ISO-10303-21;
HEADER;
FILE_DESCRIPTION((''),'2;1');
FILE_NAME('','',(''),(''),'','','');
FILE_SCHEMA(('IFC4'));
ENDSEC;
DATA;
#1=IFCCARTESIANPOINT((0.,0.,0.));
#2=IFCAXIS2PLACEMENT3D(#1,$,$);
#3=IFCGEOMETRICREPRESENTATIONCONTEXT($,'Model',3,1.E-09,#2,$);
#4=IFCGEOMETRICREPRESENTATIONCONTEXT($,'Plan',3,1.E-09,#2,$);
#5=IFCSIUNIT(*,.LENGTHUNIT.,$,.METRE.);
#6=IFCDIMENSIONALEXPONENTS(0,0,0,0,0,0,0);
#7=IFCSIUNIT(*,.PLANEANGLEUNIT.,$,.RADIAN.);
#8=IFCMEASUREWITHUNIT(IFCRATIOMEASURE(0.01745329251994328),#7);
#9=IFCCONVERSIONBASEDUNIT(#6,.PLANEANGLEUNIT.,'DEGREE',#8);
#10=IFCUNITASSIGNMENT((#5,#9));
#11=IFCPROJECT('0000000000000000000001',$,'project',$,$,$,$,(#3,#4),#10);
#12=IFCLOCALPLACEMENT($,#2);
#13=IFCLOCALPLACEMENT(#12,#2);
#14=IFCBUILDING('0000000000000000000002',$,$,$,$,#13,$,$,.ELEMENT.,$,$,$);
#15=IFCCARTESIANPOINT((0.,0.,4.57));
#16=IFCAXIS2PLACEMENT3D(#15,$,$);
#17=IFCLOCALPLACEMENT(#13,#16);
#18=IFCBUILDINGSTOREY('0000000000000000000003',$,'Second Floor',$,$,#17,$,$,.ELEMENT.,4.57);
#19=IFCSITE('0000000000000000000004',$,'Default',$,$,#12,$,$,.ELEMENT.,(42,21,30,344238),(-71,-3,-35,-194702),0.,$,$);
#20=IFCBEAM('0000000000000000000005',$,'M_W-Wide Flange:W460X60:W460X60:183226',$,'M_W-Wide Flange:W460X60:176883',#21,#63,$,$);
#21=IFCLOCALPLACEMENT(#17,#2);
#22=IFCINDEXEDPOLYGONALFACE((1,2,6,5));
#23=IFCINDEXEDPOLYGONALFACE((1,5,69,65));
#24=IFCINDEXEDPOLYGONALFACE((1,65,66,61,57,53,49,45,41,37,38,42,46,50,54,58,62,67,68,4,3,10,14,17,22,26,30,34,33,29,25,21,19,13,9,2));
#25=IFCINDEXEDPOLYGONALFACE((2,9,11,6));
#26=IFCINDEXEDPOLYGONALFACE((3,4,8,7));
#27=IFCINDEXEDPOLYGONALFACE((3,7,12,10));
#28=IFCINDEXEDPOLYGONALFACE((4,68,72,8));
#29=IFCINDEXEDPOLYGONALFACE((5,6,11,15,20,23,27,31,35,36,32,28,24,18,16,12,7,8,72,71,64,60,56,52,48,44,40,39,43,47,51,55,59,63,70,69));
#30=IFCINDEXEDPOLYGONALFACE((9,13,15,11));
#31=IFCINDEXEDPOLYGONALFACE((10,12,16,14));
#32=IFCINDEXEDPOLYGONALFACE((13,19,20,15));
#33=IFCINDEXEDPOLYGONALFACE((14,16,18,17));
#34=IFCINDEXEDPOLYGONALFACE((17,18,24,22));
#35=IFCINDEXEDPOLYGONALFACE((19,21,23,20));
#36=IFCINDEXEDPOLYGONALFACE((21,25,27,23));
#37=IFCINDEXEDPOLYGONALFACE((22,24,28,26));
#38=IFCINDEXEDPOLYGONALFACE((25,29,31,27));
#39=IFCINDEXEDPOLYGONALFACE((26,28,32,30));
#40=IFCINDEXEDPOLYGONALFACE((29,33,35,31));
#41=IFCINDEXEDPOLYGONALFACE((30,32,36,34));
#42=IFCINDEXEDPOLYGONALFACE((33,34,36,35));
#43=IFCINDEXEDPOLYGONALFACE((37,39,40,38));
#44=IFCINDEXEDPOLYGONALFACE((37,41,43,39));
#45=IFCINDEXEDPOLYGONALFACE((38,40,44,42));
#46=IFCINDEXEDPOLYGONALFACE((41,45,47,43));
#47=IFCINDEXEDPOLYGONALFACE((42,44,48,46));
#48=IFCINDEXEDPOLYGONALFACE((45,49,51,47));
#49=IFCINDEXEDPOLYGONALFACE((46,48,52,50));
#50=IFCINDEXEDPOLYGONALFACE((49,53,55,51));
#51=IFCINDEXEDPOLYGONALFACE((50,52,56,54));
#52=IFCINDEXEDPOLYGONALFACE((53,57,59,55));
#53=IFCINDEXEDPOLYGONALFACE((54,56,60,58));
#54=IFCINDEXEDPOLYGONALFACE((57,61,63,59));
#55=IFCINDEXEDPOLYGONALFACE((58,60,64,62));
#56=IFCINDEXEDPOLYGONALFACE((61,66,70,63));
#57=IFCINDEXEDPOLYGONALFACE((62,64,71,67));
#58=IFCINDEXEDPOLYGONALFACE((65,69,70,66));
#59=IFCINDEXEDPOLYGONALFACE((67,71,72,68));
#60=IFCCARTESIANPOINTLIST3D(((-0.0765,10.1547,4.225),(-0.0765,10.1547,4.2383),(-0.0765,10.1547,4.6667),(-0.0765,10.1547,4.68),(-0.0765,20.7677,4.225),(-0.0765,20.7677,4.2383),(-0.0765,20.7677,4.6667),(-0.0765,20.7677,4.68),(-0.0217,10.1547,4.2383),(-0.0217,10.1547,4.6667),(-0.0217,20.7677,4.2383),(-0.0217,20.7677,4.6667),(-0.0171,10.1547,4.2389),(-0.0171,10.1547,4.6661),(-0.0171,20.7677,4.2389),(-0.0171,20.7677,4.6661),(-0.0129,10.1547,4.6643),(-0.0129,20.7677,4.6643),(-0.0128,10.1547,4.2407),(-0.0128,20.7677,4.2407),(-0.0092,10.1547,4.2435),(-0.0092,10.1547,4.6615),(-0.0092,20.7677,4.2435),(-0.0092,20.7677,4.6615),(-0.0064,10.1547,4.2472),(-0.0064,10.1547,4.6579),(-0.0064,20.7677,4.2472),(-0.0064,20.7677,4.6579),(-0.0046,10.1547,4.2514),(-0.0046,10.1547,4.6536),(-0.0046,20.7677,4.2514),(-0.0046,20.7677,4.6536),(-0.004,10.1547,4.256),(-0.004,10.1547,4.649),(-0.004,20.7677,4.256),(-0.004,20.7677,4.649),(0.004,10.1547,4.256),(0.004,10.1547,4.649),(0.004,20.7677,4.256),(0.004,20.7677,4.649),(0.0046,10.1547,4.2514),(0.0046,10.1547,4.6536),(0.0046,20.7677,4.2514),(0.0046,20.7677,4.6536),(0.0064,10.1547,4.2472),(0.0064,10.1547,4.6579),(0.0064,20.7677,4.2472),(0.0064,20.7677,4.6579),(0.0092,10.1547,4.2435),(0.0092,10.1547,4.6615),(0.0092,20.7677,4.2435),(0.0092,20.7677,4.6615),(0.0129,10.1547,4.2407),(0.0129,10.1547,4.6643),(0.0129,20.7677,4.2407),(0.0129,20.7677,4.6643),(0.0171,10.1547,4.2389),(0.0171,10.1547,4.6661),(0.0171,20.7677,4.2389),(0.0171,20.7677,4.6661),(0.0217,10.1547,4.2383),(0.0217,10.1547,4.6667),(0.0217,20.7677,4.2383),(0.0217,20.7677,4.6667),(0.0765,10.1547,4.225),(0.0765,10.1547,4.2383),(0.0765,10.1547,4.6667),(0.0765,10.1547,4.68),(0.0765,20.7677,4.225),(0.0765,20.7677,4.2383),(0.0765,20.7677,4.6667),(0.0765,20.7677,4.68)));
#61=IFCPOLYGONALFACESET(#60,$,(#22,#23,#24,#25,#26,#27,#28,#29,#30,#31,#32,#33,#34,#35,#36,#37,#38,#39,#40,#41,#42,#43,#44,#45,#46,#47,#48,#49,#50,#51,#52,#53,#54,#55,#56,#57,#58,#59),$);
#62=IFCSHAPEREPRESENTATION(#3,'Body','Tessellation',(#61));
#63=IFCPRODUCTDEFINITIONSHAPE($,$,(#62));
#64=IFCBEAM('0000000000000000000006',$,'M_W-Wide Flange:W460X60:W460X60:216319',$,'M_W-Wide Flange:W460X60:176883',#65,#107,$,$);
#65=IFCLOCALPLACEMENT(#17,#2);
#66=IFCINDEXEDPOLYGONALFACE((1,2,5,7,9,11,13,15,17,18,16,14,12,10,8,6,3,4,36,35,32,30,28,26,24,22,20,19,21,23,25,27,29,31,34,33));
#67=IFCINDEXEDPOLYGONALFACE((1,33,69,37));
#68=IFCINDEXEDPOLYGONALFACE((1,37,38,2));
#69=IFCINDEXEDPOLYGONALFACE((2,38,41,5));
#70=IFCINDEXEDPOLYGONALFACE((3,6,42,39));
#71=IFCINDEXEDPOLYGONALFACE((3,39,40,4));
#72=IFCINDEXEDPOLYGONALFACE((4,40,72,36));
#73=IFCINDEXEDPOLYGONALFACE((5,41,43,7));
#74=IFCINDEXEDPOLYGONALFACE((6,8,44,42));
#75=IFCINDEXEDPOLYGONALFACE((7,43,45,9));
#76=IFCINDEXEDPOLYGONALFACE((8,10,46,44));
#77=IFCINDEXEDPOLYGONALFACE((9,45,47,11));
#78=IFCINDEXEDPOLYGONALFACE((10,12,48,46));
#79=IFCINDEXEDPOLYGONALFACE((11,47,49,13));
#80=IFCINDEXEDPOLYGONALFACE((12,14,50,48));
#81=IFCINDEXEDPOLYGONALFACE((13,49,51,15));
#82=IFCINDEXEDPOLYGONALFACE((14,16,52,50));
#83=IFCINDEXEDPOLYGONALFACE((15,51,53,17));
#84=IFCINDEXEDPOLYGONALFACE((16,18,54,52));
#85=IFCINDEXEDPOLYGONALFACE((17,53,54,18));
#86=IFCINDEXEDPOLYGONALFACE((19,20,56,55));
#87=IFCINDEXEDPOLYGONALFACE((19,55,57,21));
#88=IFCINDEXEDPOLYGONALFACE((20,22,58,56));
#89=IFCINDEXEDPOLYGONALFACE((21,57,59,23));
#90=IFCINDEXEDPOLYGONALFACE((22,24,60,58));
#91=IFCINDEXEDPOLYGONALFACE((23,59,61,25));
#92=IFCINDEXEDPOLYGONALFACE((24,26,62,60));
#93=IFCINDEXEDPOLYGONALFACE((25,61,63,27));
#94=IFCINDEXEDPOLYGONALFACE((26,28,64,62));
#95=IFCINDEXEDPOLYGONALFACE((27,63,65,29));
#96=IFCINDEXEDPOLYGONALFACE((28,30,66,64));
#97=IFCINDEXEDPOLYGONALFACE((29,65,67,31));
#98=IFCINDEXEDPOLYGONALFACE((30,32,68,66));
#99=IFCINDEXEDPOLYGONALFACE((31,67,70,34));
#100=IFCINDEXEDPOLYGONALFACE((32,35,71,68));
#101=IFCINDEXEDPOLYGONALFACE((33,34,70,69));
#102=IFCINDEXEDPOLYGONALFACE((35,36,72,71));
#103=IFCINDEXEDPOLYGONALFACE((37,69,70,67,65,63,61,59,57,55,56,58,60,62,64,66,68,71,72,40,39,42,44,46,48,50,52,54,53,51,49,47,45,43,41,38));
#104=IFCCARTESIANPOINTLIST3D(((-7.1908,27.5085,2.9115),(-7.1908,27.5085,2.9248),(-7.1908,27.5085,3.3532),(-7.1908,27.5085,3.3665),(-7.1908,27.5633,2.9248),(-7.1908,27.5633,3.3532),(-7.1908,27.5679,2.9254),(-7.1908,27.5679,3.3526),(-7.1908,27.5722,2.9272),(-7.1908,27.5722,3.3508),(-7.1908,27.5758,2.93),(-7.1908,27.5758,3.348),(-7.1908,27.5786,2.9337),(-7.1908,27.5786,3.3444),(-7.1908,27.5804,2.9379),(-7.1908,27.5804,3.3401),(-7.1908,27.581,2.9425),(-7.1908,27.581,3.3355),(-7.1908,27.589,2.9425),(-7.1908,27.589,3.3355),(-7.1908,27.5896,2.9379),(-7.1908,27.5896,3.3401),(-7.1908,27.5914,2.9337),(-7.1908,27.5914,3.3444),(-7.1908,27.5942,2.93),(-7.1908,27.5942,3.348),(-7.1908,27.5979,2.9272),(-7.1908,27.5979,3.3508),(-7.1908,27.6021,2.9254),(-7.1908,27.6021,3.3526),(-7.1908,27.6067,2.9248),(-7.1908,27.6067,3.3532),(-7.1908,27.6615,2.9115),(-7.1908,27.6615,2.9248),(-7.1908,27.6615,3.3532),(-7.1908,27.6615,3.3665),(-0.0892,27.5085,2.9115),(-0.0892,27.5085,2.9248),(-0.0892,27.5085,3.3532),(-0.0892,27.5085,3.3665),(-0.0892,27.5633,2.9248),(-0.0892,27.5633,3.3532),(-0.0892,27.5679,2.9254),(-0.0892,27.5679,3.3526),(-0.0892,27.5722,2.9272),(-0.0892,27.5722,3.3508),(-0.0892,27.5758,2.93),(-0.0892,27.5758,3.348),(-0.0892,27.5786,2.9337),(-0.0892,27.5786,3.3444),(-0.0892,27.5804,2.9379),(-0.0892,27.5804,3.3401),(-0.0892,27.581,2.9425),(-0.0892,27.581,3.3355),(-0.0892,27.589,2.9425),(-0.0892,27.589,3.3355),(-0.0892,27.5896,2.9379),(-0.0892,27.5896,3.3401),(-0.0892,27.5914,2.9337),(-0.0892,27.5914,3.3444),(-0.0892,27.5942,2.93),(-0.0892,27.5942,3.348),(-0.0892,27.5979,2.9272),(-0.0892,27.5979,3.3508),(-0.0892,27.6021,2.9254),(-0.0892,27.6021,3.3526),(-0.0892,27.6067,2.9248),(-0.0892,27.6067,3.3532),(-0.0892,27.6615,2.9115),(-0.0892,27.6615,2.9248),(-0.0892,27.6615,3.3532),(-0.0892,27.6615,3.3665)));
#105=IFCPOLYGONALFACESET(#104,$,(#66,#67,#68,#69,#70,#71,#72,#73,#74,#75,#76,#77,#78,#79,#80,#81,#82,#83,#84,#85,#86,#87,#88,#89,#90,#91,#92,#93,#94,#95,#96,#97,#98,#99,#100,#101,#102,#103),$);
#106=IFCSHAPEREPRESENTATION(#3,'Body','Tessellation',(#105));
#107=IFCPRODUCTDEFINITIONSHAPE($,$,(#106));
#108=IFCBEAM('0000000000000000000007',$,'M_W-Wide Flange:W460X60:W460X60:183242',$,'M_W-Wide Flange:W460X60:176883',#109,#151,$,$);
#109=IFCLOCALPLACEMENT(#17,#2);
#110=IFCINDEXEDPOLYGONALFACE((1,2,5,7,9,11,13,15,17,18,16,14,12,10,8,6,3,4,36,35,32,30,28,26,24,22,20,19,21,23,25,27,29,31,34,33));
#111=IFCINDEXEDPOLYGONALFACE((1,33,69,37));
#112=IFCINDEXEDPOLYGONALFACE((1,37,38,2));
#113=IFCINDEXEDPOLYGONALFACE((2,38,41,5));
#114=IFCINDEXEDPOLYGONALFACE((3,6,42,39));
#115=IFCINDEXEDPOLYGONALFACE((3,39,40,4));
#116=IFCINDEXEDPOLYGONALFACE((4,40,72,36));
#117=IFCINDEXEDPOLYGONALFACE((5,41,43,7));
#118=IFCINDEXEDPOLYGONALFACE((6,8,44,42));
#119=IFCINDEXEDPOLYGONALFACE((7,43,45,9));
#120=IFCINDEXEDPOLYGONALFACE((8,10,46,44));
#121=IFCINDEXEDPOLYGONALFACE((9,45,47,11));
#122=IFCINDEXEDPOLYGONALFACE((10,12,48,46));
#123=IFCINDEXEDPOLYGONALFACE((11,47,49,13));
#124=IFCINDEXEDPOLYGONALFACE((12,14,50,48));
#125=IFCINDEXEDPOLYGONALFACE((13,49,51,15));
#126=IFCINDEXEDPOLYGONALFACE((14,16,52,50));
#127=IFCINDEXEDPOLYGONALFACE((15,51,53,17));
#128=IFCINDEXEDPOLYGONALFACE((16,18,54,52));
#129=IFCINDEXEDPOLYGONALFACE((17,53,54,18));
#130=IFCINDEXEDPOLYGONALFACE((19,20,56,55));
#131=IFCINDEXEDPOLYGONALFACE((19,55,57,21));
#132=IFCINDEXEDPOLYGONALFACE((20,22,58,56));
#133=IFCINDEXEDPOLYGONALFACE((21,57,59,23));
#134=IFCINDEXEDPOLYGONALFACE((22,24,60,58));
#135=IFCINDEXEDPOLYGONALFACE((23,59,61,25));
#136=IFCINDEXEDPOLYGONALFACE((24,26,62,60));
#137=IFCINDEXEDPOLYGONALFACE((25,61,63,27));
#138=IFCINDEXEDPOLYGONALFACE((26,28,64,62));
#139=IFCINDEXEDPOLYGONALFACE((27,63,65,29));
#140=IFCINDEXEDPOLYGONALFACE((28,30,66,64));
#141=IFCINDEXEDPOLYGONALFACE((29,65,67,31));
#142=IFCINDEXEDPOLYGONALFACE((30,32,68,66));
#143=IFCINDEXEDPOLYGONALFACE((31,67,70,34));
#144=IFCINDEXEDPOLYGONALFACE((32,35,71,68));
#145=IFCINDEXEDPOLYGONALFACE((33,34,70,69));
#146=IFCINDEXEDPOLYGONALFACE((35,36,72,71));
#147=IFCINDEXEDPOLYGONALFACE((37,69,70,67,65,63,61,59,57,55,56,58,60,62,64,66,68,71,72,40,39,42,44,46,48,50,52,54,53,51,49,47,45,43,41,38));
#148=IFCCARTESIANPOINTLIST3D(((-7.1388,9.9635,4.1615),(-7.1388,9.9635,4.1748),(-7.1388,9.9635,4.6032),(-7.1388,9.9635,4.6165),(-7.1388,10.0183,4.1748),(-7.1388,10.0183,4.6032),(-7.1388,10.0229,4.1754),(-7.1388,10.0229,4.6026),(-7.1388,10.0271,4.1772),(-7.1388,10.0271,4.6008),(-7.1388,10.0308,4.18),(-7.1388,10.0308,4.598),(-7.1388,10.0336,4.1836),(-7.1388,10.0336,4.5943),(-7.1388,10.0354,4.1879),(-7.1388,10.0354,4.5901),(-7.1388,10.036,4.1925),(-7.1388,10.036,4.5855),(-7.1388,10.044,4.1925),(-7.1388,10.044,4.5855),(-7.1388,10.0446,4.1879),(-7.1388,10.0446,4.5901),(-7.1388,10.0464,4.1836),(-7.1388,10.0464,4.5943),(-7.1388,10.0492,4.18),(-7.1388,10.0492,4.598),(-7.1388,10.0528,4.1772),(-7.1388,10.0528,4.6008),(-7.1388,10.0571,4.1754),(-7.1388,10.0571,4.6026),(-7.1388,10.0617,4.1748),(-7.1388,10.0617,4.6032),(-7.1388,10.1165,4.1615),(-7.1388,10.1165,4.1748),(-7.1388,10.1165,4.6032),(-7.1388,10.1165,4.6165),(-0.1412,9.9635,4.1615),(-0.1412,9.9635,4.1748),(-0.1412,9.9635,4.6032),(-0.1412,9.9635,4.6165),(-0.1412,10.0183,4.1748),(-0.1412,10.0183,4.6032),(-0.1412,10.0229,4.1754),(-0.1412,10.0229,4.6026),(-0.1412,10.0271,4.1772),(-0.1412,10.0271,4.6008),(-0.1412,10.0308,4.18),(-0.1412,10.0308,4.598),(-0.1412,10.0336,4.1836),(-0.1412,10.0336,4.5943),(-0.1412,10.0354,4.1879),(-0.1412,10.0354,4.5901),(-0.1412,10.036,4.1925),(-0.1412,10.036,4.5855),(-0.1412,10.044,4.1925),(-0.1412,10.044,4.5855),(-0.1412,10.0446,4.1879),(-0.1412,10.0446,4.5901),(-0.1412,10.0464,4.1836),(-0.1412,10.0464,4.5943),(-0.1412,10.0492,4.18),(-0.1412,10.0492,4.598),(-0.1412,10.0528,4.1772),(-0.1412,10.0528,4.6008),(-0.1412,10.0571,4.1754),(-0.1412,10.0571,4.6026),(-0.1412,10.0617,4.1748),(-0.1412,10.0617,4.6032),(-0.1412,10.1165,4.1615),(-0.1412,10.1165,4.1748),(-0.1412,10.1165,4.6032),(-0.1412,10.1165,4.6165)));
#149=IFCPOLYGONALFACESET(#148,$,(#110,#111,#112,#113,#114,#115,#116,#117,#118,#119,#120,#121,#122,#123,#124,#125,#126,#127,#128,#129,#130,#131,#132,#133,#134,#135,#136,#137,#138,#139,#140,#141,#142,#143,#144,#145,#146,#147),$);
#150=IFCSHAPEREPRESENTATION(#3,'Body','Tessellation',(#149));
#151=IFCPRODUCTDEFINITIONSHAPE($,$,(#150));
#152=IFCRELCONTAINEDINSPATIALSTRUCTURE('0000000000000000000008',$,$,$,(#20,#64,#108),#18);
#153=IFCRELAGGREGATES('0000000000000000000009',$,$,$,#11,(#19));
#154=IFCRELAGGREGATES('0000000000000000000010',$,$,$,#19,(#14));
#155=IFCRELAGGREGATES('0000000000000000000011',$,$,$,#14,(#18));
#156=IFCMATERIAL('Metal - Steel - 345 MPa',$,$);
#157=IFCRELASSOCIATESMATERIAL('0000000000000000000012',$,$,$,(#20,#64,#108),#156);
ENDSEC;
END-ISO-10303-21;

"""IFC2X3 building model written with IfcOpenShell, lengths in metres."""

from ifc_helpers import new_model, entity, si_unit, converted_unit, frame, frame_2d, origin, place, context, project, spatial, polyline, circle_curve, parameter, trimmed, segment, composite_curve, outline, extrude, material, element, save


model = new_model("IFC2X3")

# Units and contexts
model_context = context("Model", 3, precision=1e-09, world=origin())
plan_context = context("Plan", 3, precision=1e-09, world=origin())
ifc_project = project(units=[si_unit("LENGTHUNIT", "METRE"), converted_unit("PLANEANGLEUNIT", "DEGREE", entity("IfcRatioMeasure", 0.01745329251994328), si_unit("PLANEANGLEUNIT", "RADIAN"), dimensions=[0, 0, 0, 0, 0, 0, 0])], contexts=[model_context, plan_context])

# Site, building, storey
site_placement = place(None, origin())
site = spatial("IfcSite", under=ifc_project, at=site_placement, Name="Default", CompositionType="ELEMENT", RefLatitude=(42, 21, 30, 344238), RefLongitude=(-71, -3, -35, -194702), RefElevation=0.0)
building_placement = place(site_placement, origin())
building = spatial("IfcBuilding", under=site, at=building_placement, CompositionType="ELEMENT")
storey_placement = place(building_placement, frame((0.0, 0.0, 4.57)))
storey = spatial("IfcBuildingStorey", under=building, at=storey_placement, Name="Second Floor", CompositionType="ELEMENT", Elevation=4.57)

# Shared definitions
ifc_material = material(Name="Metal - Steel - 345 MPa")

# Beams
beam_1_placement = place(storey_placement, frame((0.0, 20.9072, 4.68), z_axis=(0.0, 0.0, 1.0), x_axis=(-1.0, 0.0, 0.0)))
element("IfcBeam", 1, at=beam_1_placement, inside=storey, material=ifc_material, Name="M_W-Wide Flange:W460X60:W460X60:183226", ObjectType="M_W-Wide Flange:W460X60:176883", context=model_context, shape_type="SweptSolid", body=[
    extrude(outline(composite_curve([segment(polyline([(0.2142, -0.0765), (0.2275, -0.0765)]), True, "CONTINUOUS"), segment(polyline([(0.2275, -0.0765), (0.2275, 0.0765)]), True, "CONTINUOUS"), segment(polyline([(0.2275, 0.0765), (0.2142, 0.0765)]), True, "CONTINUOUS"), segment(polyline([(0.2142, 0.0765), (0.2142, 0.0217)]), True, "CONTINUOUS"), segment(trimmed(circle_curve(frame_2d((0.1965, 0.0217), x_axis=(1.0, 0.0)), 0.0177), [parameter(270.0)], [parameter(360.0)], True, "PARAMETER"), False, "CONTINUOUS"), segment(polyline([(0.1965, 0.004), (-0.1965, 0.004)]), True, "CONTINUOUS"), segment(trimmed(circle_curve(frame_2d((-0.1965, 0.0217), x_axis=(0.0, -1.0)), 0.0177), [parameter(270.0)], [parameter(360.0)], True, "PARAMETER"), False, "CONTINUOUS"), segment(polyline([(-0.2142, 0.0217), (-0.2142, 0.0765)]), True, "CONTINUOUS"), segment(polyline([(-0.2142, 0.0765), (-0.2275, 0.0765)]), True, "CONTINUOUS"), segment(polyline([(-0.2275, 0.0765), (-0.2275, -0.0765)]), True, "CONTINUOUS"), segment(polyline([(-0.2275, -0.0765), (-0.2142, -0.0765)]), True, "CONTINUOUS"), segment(polyline([(-0.2142, -0.0765), (-0.2142, -0.0217)]), True, "CONTINUOUS"), segment(trimmed(circle_curve(frame_2d((-0.1965, -0.0217), x_axis=(-1.0, 0.0)), 0.0177), [parameter(270.0)], [parameter(360.0)], True, "PARAMETER"), False, "CONTINUOUS"), segment(polyline([(-0.1965, -0.004), (0.1965, -0.004)]), True, "CONTINUOUS"), segment(trimmed(circle_curve(frame_2d((0.1965, -0.0217), x_axis=(0.0, 1.0)), 0.0177), [parameter(270.0)], [parameter(0.0)], True, "PARAMETER"), False, "CONTINUOUS"), segment(polyline([(0.2142, -0.0217), (0.2142, -0.0765)]), True, "CONTINUOUS")], self_intersect=False)), frame((0.0, 10.7525, -0.2275), z_axis=(0.0, -1.0, 0.0), x_axis=(0.0, 0.0, -1.0)), (0.0, 0.0, 1.0), 10.613),
])
beam_2_placement = place(storey_placement, frame((-7.2774, 27.585, 3.3665), z_axis=(0.0, 0.0, 1.0), x_axis=(0.0, -1.0, 0.0)))
element("IfcBeam", 2, at=beam_2_placement, inside=storey, material=ifc_material, Name="M_W-Wide Flange:W460X60:W460X60:216319", ObjectType="M_W-Wide Flange:W460X60:176883", context=model_context, shape_type="SweptSolid", body=[
    extrude(outline(composite_curve([segment(polyline([(0.2142, -0.0765), (0.2275, -0.0765)]), True, "CONTINUOUS"), segment(polyline([(0.2275, -0.0765), (0.2275, 0.0765)]), True, "CONTINUOUS"), segment(polyline([(0.2275, 0.0765), (0.2142, 0.0765)]), True, "CONTINUOUS"), segment(polyline([(0.2142, 0.0765), (0.2142, 0.0217)]), True, "CONTINUOUS"), segment(trimmed(circle_curve(frame_2d((0.1965, 0.0217), x_axis=(0.0, 1.0)), 0.0177), [parameter(180.0)], [parameter(270.0)], True, "PARAMETER"), False, "CONTINUOUS"), segment(polyline([(0.1965, 0.004), (-0.1965, 0.004)]), True, "CONTINUOUS"), segment(trimmed(circle_curve(frame_2d((-0.1965, 0.0217), x_axis=(0.0, 1.0)), 0.0177), [parameter(90.0)], [parameter(180.0)], True, "PARAMETER"), False, "CONTINUOUS"), segment(polyline([(-0.2142, 0.0217), (-0.2142, 0.0765)]), True, "CONTINUOUS"), segment(polyline([(-0.2142, 0.0765), (-0.2275, 0.0765)]), True, "CONTINUOUS"), segment(polyline([(-0.2275, 0.0765), (-0.2275, -0.0765)]), True, "CONTINUOUS"), segment(polyline([(-0.2275, -0.0765), (-0.2142, -0.0765)]), True, "CONTINUOUS"), segment(polyline([(-0.2142, -0.0765), (-0.2142, -0.0217)]), True, "CONTINUOUS"), segment(trimmed(circle_curve(frame_2d((-0.1965, -0.0217), x_axis=(0.0, 1.0)), 0.0177), [parameter(360.0)], [parameter(90.0)], True, "PARAMETER"), False, "CONTINUOUS"), segment(polyline([(-0.1965, -0.004), (0.1965, -0.004)]), True, "CONTINUOUS"), segment(trimmed(circle_curve(frame_2d((0.1965, -0.0217), x_axis=(0.0, 1.0)), 0.0177), [parameter(270.0)], [parameter(0.0)], True, "PARAMETER"), False, "CONTINUOUS"), segment(polyline([(0.2142, -0.0217), (0.2142, -0.0765)]), True, "CONTINUOUS")], self_intersect=False)), frame((0.0, 0.0866, -0.2275), z_axis=(0.0, 1.0, 0.0), x_axis=(0.0, 0.0, -1.0)), (0.0, 0.0, 1.0), 7.1016),
])
beam_3_placement = place(storey_placement, frame((-0.0026, 10.04, 4.6165), z_axis=(0.0, 0.0, 1.0), x_axis=(0.0, 1.0, 0.0)))
element("IfcBeam", 3, at=beam_3_placement, inside=storey, material=ifc_material, Name="M_W-Wide Flange:W460X60:W460X60:183242", ObjectType="M_W-Wide Flange:W460X60:176883", context=model_context, shape_type="SweptSolid", body=[
    extrude(outline(composite_curve([segment(polyline([(0.2142, -0.0765), (0.2275, -0.0765)]), True, "CONTINUOUS"), segment(polyline([(0.2275, -0.0765), (0.2275, 0.0765)]), True, "CONTINUOUS"), segment(polyline([(0.2275, 0.0765), (0.2142, 0.0765)]), True, "CONTINUOUS"), segment(polyline([(0.2142, 0.0765), (0.2142, 0.0217)]), True, "CONTINUOUS"), segment(trimmed(circle_curve(frame_2d((0.1965, 0.0217), x_axis=(1.0, 0.0)), 0.0177), [parameter(270.0)], [parameter(360.0)], True, "PARAMETER"), False, "CONTINUOUS"), segment(polyline([(0.1965, 0.004), (-0.1965, 0.004)]), True, "CONTINUOUS"), segment(trimmed(circle_curve(frame_2d((-0.1965, 0.0217), x_axis=(0.0, -1.0)), 0.0177), [parameter(270.0)], [parameter(360.0)], True, "PARAMETER"), False, "CONTINUOUS"), segment(polyline([(-0.2142, 0.0217), (-0.2142, 0.0765)]), True, "CONTINUOUS"), segment(polyline([(-0.2142, 0.0765), (-0.2275, 0.0765)]), True, "CONTINUOUS"), segment(polyline([(-0.2275, 0.0765), (-0.2275, -0.0765)]), True, "CONTINUOUS"), segment(polyline([(-0.2275, -0.0765), (-0.2142, -0.0765)]), True, "CONTINUOUS"), segment(polyline([(-0.2142, -0.0765), (-0.2142, -0.0217)]), True, "CONTINUOUS"), segment(trimmed(circle_curve(frame_2d((-0.1965, -0.0217), x_axis=(-1.0, 0.0)), 0.0177), [parameter(270.0)], [parameter(360.0)], True, "PARAMETER"), False, "CONTINUOUS"), segment(polyline([(-0.1965, -0.004), (0.1965, -0.004)]), True, "CONTINUOUS"), segment(trimmed(circle_curve(frame_2d((0.1965, -0.0217), x_axis=(0.0, 1.0)), 0.0177), [parameter(270.0)], [parameter(0.0)], True, "PARAMETER"), False, "CONTINUOUS"), segment(polyline([(0.2142, -0.0217), (0.2142, -0.0765)]), True, "CONTINUOUS")], self_intersect=False)), frame((0.0, 7.1362, -0.2275), z_axis=(0.0, -1.0, 0.0), x_axis=(0.0, 0.0, -1.0)), (0.0, 0.0, 1.0), 6.9976),
])

save(model, "model.ifc")
